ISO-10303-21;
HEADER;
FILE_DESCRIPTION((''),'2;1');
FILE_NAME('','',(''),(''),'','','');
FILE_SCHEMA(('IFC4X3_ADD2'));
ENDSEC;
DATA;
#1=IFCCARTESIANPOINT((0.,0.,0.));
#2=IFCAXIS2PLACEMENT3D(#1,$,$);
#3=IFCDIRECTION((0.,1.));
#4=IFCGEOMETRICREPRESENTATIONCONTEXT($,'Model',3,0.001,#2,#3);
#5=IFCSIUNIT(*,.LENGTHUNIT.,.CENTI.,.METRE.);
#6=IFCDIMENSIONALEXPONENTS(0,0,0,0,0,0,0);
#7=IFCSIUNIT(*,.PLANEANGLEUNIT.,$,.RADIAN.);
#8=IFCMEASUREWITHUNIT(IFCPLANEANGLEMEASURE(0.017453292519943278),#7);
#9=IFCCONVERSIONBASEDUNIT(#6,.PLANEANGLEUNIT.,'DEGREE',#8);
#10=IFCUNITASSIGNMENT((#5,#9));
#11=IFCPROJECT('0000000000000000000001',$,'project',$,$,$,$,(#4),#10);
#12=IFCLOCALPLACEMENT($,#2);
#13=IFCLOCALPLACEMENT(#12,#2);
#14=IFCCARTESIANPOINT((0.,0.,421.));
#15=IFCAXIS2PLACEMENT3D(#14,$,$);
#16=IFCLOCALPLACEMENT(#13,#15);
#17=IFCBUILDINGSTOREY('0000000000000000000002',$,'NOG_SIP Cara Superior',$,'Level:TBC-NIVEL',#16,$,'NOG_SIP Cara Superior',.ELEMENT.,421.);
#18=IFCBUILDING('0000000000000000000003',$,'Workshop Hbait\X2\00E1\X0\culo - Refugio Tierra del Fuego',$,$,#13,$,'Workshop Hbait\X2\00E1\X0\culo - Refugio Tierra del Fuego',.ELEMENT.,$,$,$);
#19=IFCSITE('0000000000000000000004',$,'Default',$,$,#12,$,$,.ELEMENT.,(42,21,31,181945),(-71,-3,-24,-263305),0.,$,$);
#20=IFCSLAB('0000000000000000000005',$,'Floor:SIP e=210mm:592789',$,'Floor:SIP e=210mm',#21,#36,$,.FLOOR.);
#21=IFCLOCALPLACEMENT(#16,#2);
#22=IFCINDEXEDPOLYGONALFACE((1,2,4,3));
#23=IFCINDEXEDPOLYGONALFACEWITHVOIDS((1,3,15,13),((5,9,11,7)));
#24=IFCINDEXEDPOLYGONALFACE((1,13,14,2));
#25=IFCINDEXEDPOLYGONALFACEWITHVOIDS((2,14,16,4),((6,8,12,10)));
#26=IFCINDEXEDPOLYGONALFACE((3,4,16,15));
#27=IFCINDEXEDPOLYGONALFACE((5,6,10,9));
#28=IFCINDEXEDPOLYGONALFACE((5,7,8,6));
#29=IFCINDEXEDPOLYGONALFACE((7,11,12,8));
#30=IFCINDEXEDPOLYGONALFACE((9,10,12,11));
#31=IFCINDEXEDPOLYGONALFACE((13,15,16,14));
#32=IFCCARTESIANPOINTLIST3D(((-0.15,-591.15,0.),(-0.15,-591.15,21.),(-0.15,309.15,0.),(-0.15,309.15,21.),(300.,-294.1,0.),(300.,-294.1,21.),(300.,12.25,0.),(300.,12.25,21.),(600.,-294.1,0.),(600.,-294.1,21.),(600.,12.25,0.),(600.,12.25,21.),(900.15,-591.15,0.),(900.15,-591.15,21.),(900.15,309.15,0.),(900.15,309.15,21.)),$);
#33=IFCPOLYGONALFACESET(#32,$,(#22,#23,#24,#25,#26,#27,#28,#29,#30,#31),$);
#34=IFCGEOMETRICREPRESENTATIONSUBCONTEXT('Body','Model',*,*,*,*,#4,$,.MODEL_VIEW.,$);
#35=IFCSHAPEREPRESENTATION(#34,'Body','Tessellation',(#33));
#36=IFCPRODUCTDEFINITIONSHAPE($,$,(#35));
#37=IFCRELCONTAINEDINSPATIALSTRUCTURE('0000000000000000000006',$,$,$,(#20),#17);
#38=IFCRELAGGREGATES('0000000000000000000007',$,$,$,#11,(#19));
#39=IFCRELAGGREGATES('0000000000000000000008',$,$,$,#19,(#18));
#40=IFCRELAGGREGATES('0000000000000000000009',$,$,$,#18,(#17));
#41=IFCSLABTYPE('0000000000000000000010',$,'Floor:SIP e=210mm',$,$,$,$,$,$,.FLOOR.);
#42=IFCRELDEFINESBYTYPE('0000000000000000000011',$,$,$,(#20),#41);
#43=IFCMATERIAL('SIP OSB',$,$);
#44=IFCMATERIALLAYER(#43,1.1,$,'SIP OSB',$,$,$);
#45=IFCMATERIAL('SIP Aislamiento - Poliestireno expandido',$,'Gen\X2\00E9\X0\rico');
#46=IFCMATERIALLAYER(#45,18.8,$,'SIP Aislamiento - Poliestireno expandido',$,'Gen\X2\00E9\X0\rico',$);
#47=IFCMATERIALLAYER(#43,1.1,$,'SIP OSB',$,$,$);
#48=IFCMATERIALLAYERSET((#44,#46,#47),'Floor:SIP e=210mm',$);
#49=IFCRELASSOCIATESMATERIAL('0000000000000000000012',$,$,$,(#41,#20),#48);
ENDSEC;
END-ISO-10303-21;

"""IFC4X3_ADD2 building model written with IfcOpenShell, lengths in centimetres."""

from ifc_helpers import new_model, entity, si_unit, converted_unit, direction, frame, frame_2d, origin, origin_2d_with_axis, place, context, subcontext, project, spatial, rectangle, extrude, boolean, material, layer, layer_set, layer_usage, type_object, element, save


model = new_model("IFC4X3_ADD2")

# Units and contexts
model_context = context("Model", 3, precision=0.001, world=origin(), true_north=direction((0.0, 1.0)))
body_context = subcontext(model_context, "Body", "Model", "MODEL_VIEW")
ifc_project = project(units=[si_unit("LENGTHUNIT", "METRE", prefix="CENTI"), converted_unit("PLANEANGLEUNIT", "DEGREE", entity("IfcPlaneAngleMeasure", 0.017453292519943278), si_unit("PLANEANGLEUNIT", "RADIAN"), dimensions=[0, 0, 0, 0, 0, 0, 0])], contexts=[model_context])

# Site, building, storey
site_placement = place(None, origin())
site = spatial("IfcSite", under=ifc_project, at=site_placement, Name="Default", CompositionType="ELEMENT", RefLatitude=(42, 21, 31, 181945), RefLongitude=(-71, -3, -24, -263305), RefElevation=0.0)
building_placement = place(site_placement, origin())
building = spatial("IfcBuilding", under=site, at=building_placement, Name="Workshop Hbaitáculo - Refugio Tierra del Fuego", LongName="Workshop Hbaitáculo - Refugio Tierra del Fuego", CompositionType="ELEMENT")
storey_placement = place(building_placement, frame((0.0, 0.0, 421.0)))
storey = spatial("IfcBuildingStorey", under=building, at=storey_placement, Name="NOG_SIP Cara Superior", ObjectType="Level:TBC-NIVEL", LongName="NOG_SIP Cara Superior", CompositionType="ELEMENT", Elevation=421.0)

# Slab, opening
ifc_material_1 = material(Name="SIP OSB")
ifc_layer_1 = layer(ifc_material_1, 1.1, Name="SIP OSB")
ifc_material_2 = material(Name="SIP Aislamiento - Poliestireno expandido", Category="Genérico")
ifc_layer_2 = layer(ifc_material_2, 18.8, Name="SIP Aislamiento - Poliestireno expandido", Category="Genérico")
ifc_layer_3 = layer(ifc_material_1, 1.1, Name="SIP OSB")
ifc_layer_set = layer_set([ifc_layer_1, ifc_layer_2, ifc_layer_3], Name="Floor:SIP e=210mm")
ifc_layer_usage = layer_usage(ifc_layer_set, "AXIS3", "POSITIVE", 0.0)
slab_type = type_object("IfcSlabType", Name="Floor:SIP e=210mm", PredefinedType="FLOOR", material=ifc_layer_set)
slab_placement = place(storey_placement, origin())
slab = element("IfcSlab", 1, at=slab_placement, inside=storey, type_object=slab_type, material=ifc_layer_usage, Name="Floor:SIP e=210mm:592789", ObjectType="Floor:SIP e=210mm", PredefinedType="FLOOR", context=body_context, shape_type="CSG", body=[
    boolean("DIFFERENCE", extrude(rectangle(XDim=900.3, YDim=900.3, at=origin_2d_with_axis()), frame((450.0, -141.0, 21.0), z_axis=(0.0, 0.0, -1.0), x_axis=(0.0, 1.0, 0.0)), (0.0, 0.0, 1.0), 21.0), extrude(rectangle(XDim=306.35, YDim=300.0, at=frame_2d((0.0, 0.0), x_axis=(1.0, 0.0))), frame((450.0, -140.93, 0.0), z_axis=(0.0, 0.0, 1.0), x_axis=(0.0, 1.0, 0.0)), (0.0, 0.0, 1.0), 21.0)),
])
opening_placement = place(slab_placement, origin())
element("IfcOpeningElement", 2, at=opening_placement, cuts=slab, PredefinedType="OPENING", context=body_context, shape_type="SweptSolid", body=[
    extrude(rectangle(XDim=306.35, YDim=300.0, at=frame_2d((450.0, -140.93), x_axis=(0.0, -1.0))), frame((0.0, 0.0, 21.0)), (0.0, 0.0, -1.0), 21.0),
])

save(model, "model.ifc")
